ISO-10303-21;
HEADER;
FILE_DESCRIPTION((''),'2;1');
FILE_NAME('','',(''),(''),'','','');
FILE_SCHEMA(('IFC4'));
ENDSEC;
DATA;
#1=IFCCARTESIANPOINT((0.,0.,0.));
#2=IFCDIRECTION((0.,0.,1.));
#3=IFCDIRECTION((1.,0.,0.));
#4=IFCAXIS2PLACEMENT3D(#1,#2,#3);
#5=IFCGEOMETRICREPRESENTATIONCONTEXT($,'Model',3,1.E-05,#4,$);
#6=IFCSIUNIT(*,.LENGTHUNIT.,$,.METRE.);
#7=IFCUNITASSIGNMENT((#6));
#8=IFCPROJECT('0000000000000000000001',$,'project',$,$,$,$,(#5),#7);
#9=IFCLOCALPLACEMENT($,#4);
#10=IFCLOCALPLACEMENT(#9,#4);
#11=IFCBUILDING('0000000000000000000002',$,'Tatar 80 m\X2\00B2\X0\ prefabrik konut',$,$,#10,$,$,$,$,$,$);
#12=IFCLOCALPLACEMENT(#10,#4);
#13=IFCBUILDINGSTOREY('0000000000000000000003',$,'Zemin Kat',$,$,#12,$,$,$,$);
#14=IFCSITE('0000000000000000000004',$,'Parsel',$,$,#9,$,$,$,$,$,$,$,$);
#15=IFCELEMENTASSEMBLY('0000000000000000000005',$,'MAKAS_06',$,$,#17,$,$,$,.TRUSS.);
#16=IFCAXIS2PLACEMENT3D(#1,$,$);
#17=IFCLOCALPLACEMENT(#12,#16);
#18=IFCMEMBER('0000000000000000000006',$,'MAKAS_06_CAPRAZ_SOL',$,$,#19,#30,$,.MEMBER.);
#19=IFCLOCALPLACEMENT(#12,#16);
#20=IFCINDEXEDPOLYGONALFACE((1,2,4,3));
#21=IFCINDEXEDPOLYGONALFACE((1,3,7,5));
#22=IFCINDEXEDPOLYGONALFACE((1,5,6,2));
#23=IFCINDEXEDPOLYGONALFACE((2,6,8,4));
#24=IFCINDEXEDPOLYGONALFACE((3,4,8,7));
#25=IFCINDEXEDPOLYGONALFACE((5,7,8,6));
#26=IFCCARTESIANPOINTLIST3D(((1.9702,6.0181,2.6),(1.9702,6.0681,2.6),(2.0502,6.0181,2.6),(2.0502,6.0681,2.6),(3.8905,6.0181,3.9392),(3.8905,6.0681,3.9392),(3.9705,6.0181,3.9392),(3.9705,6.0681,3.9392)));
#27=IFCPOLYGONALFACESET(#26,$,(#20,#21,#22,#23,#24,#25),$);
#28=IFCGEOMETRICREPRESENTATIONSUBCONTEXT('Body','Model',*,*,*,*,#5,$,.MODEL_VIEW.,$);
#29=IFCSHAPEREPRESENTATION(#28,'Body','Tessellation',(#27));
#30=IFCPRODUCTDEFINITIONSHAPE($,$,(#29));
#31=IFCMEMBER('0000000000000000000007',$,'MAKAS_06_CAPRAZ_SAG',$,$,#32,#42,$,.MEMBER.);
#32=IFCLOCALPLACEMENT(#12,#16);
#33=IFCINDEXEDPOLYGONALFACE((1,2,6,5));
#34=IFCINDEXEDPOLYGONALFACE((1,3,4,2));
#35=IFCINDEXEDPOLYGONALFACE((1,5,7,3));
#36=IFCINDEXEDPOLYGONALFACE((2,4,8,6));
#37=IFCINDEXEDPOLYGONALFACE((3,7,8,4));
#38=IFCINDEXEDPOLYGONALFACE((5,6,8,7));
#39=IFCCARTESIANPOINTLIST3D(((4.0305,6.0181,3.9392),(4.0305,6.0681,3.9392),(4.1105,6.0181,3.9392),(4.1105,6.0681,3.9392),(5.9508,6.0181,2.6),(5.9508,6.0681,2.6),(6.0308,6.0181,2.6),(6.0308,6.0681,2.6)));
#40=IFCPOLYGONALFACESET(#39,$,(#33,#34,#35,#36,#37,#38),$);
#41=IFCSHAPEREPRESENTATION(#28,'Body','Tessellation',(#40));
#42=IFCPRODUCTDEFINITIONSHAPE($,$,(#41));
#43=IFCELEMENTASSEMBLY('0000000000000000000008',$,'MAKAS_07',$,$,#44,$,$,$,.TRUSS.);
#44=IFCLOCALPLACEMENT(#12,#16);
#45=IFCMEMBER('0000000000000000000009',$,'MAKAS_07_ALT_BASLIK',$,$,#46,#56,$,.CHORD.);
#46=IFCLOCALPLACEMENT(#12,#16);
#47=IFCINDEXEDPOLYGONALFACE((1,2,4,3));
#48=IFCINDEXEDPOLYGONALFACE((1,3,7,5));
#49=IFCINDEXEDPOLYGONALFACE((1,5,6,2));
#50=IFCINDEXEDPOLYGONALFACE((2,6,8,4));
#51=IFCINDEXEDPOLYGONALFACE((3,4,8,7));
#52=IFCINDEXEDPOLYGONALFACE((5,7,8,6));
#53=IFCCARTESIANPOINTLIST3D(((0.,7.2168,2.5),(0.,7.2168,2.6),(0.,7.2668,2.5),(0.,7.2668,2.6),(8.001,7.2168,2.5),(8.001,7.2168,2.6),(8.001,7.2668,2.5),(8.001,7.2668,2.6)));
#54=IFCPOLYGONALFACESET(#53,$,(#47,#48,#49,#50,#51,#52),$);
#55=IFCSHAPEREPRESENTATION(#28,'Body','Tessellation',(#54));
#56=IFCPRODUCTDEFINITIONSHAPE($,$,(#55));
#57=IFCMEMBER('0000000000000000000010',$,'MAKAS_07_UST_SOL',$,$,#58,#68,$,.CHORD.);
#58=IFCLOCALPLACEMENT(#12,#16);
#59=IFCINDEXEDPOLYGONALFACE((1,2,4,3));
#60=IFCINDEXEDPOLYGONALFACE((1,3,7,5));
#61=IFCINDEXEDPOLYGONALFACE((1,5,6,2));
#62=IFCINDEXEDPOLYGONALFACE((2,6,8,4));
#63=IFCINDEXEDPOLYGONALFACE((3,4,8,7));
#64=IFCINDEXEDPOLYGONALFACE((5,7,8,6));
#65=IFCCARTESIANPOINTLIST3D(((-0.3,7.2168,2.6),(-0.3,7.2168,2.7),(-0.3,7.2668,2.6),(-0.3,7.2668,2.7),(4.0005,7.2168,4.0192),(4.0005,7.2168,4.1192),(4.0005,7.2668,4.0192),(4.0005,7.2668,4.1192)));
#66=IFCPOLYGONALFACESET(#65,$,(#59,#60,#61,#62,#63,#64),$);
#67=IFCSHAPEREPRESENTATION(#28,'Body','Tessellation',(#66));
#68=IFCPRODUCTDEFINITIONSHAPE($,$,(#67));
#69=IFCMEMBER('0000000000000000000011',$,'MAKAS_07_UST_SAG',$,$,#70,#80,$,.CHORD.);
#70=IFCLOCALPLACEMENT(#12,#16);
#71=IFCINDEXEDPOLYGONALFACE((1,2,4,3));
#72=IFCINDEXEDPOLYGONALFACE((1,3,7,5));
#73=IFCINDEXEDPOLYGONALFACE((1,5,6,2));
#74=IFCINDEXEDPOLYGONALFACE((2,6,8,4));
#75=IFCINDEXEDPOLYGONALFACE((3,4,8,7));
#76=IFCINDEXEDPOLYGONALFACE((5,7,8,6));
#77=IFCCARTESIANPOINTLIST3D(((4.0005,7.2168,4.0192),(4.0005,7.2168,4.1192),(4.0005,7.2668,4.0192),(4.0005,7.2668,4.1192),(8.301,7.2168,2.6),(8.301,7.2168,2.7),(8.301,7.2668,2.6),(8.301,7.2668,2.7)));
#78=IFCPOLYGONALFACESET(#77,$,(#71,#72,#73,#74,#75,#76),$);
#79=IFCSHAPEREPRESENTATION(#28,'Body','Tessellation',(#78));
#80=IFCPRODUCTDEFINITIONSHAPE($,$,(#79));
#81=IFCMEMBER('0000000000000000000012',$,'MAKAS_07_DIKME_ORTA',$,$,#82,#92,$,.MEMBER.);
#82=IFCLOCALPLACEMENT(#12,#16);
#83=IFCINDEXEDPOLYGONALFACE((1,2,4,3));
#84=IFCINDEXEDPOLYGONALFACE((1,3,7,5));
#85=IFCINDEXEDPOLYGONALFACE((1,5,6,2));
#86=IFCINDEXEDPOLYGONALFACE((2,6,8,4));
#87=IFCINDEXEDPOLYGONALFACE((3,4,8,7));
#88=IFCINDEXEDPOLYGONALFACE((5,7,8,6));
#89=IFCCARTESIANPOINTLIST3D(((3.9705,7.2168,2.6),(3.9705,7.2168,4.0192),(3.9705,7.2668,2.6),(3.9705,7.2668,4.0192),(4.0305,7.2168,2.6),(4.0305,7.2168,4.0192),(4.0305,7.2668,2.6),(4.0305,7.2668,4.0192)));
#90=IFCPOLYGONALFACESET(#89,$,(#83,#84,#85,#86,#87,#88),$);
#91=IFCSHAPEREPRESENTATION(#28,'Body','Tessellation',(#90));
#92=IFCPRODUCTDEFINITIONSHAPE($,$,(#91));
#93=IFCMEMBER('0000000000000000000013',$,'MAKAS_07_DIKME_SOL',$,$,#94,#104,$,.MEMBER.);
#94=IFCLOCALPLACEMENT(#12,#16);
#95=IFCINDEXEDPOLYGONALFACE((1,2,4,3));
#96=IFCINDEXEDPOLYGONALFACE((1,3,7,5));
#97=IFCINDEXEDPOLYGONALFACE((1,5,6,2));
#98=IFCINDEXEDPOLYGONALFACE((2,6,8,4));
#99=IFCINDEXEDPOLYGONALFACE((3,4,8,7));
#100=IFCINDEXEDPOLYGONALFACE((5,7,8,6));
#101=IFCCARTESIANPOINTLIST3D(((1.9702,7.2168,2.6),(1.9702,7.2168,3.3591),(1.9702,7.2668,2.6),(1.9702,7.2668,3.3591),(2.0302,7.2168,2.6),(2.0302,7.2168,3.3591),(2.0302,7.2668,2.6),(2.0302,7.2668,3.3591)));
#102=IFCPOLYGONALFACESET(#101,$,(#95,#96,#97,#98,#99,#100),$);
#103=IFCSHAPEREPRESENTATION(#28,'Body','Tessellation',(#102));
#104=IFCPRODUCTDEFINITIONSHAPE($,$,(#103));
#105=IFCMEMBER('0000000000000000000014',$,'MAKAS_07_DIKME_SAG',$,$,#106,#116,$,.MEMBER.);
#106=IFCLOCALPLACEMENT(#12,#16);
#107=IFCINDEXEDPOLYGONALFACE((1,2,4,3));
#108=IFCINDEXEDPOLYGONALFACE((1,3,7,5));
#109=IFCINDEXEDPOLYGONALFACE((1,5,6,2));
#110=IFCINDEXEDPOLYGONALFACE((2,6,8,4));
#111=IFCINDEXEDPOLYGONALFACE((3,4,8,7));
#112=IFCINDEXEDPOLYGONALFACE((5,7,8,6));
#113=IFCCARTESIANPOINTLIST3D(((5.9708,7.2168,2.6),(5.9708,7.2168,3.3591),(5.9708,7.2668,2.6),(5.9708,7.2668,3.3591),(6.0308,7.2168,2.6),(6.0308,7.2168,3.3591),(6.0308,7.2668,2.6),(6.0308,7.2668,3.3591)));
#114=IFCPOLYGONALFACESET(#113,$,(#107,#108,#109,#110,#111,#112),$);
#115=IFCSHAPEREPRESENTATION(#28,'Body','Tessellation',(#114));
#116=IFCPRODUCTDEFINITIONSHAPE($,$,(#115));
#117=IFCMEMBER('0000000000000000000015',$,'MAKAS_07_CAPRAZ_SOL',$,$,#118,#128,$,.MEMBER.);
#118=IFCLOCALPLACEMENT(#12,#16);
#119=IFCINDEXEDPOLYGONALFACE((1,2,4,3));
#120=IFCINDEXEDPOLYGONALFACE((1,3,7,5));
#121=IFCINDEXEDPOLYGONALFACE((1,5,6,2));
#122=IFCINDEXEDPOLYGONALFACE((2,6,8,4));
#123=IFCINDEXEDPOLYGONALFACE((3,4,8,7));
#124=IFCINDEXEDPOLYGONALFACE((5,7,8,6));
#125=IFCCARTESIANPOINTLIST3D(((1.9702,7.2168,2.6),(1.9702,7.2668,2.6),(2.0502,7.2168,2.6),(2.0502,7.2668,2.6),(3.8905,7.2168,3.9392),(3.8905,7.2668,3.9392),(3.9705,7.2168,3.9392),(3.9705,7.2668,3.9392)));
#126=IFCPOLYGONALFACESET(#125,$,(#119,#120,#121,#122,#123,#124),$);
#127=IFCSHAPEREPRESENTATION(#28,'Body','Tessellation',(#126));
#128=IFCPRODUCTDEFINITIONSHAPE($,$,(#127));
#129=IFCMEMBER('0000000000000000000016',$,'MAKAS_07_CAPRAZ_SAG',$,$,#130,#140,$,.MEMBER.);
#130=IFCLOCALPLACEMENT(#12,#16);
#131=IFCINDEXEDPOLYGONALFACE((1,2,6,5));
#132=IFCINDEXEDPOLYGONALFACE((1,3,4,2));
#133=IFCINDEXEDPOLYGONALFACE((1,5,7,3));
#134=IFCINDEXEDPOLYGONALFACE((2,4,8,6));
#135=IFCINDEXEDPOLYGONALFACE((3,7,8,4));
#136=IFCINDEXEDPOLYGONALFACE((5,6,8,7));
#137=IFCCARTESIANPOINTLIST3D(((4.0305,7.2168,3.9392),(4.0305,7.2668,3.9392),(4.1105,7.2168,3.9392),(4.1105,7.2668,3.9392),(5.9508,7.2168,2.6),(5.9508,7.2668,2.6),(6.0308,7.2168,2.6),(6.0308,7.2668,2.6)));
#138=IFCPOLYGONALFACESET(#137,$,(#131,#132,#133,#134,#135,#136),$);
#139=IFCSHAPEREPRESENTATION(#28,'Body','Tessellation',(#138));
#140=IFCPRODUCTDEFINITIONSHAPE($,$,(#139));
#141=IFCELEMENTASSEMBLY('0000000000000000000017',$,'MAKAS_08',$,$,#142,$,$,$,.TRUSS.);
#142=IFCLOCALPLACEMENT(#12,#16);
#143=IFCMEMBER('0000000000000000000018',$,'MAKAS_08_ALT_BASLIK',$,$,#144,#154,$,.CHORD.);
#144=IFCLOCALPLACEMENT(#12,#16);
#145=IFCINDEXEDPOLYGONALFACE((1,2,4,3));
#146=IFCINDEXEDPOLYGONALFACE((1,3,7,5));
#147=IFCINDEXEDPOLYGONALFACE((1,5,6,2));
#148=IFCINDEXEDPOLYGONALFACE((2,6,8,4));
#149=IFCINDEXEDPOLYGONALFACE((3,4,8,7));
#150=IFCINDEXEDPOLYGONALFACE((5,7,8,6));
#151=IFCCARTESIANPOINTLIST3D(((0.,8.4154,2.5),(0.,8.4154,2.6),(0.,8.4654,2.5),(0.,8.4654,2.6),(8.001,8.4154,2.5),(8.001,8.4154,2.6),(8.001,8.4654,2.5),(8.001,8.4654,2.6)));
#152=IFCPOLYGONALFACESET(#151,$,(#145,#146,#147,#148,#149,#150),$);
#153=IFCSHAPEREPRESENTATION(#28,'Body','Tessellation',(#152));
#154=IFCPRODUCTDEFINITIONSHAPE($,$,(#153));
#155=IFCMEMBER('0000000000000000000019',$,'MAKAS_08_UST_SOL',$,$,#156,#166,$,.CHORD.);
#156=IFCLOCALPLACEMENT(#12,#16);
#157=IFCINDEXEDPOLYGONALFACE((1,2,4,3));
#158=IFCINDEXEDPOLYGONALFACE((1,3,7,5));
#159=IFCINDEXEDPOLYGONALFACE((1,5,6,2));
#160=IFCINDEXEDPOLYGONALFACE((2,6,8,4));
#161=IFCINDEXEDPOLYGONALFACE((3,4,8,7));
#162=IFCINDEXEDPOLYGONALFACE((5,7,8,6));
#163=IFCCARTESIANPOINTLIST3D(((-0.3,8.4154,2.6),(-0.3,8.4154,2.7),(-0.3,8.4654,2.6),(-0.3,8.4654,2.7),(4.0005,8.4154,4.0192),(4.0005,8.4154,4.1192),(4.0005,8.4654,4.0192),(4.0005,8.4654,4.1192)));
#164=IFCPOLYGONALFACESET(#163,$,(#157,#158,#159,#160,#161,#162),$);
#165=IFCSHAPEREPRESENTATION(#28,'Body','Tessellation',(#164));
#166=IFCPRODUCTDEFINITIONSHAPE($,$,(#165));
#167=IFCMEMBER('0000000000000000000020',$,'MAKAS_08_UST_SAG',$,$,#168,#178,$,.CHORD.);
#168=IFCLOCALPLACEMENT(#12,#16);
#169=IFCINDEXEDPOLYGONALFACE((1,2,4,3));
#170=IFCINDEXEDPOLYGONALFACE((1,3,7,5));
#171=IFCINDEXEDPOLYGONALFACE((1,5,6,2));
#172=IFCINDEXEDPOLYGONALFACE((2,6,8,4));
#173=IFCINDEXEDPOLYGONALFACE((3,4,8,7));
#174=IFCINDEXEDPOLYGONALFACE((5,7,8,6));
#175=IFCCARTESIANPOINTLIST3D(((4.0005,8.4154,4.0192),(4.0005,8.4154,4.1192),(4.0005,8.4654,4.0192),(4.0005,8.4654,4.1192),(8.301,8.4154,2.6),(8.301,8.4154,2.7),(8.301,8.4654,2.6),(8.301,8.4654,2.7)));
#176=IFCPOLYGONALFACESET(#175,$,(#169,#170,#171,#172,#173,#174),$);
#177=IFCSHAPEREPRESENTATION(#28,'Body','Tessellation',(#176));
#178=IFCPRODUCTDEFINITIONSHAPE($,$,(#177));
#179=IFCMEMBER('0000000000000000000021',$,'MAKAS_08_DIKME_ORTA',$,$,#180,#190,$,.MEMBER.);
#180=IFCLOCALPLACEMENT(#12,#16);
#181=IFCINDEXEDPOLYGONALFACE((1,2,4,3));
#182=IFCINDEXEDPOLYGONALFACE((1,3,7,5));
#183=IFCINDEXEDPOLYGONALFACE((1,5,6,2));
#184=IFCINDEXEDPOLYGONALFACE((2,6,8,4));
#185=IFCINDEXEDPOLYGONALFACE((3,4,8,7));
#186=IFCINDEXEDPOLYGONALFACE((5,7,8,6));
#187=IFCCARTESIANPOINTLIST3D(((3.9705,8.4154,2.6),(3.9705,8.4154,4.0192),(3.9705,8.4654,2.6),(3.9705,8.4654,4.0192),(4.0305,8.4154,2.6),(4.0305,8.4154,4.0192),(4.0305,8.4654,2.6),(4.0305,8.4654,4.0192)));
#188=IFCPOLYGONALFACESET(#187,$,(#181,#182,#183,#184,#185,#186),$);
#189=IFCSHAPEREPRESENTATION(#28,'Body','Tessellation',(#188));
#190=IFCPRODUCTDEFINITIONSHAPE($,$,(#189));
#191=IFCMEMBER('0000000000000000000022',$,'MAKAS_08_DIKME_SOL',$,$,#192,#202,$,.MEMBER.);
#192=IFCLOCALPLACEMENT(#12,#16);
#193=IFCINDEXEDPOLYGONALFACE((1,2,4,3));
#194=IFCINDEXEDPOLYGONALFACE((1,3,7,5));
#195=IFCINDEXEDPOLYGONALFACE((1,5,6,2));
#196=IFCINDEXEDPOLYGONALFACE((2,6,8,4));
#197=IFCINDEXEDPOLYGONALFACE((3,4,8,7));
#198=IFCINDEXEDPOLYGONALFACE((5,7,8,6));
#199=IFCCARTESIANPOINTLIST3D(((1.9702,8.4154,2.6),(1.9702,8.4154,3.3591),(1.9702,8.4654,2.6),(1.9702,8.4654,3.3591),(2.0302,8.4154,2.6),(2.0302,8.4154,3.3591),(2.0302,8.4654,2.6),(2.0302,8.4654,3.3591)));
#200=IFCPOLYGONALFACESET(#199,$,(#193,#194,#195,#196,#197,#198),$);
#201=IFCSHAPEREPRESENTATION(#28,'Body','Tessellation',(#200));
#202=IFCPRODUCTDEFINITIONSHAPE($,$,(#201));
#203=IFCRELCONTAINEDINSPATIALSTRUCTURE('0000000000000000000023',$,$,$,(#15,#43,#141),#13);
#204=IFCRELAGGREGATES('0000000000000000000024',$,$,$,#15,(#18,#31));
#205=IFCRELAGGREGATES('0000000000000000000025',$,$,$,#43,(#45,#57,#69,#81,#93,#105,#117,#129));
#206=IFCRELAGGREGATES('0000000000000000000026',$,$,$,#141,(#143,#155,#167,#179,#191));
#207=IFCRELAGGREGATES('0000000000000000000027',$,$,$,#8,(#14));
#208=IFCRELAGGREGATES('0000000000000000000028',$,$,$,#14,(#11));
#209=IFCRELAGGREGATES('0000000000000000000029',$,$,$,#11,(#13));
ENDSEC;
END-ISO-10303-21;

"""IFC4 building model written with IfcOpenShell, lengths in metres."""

from ifc_helpers import new_model, si_unit, frame, origin_with_axes, place, context, subcontext, project, spatial, line, indexed_curve, outline, extrude, element, aggregate, save


model = new_model("IFC4")

# Units and contexts
model_context = context("Model", 3, precision=1e-05, world=origin_with_axes())
body_context = subcontext(model_context, "Body", "Model", "MODEL_VIEW")
ifc_project = project(units=[si_unit("LENGTHUNIT", "METRE")], contexts=[model_context])

# Site, building, storey
site_placement = place(None, origin_with_axes())
site = spatial("IfcSite", under=ifc_project, at=site_placement, Name="Parsel")
building_placement = place(site_placement, origin_with_axes())
building = spatial("IfcBuilding", under=site, at=building_placement, Name="Tatar 80 m² prefabrik konut")
storey_placement = place(building_placement, origin_with_axes())
storey = spatial("IfcBuildingStorey", under=building, at=storey_placement, Name="Zemin Kat")

# Element assemblies, members
assembly_1_placement = place(storey_placement, origin_with_axes())
assembly_1 = element("IfcElementAssembly", 1, at=assembly_1_placement, inside=storey, Name="MAKAS_06", PredefinedType="TRUSS")
member_1_placement = place(assembly_1_placement, origin_with_axes())
member_1 = element("IfcMember", 2, at=member_1_placement, Name="MAKAS_06_CAPRAZ_SOL", PredefinedType="MEMBER", context=body_context, shape_type="SweptSolid", body=[
    extrude(outline(indexed_curve([(1.9703, 2.6), (2.0503, 2.6), (3.9705, 3.9392), (3.8905, 3.9392)], segments=[line(1, 2, 3, 4, 1)])), frame((0.0, 6.0681, 0.0), z_axis=(0.0, -1.0, 0.0), x_axis=(1.0, 0.0, 0.0)), (0.0, 0.0, 1.0), 0.05),
])
member_2_placement = place(assembly_1_placement, origin_with_axes())
member_2 = element("IfcMember", 3, at=member_2_placement, Name="MAKAS_06_CAPRAZ_SAG", PredefinedType="MEMBER", context=body_context, shape_type="SweptSolid", body=[
    extrude(outline(indexed_curve([(5.9508, 2.6), (6.0308, 2.6), (4.1105, 3.9392), (4.0305, 3.9392)], segments=[line(1, 2, 3, 4, 1)])), frame((0.0, 6.0681, 0.0), z_axis=(0.0, -1.0, 0.0), x_axis=(1.0, 0.0, 0.0)), (0.0, 0.0, 1.0), 0.05),
])
aggregate(assembly_1, [member_1, member_2])
assembly_2_placement = place(storey_placement, origin_with_axes())
assembly_2 = element("IfcElementAssembly", 4, at=assembly_2_placement, inside=storey, Name="MAKAS_07", PredefinedType="TRUSS")
member_3_placement = place(assembly_2_placement, origin_with_axes())
member_3 = element("IfcMember", 5, at=member_3_placement, Name="MAKAS_07_ALT_BASLIK", PredefinedType="CHORD", context=body_context, shape_type="SweptSolid", body=[
    extrude(outline(indexed_curve([(0.0, 2.5), (8.001, 2.5), (8.001, 2.6), (0.0, 2.6)], segments=[line(1, 2, 3, 4, 1)])), frame((0.0, 7.2668, 0.0), z_axis=(0.0, -1.0, 0.0), x_axis=(1.0, 0.0, 0.0)), (0.0, 0.0, 1.0), 0.05),
])
member_4_placement = place(assembly_2_placement, origin_with_axes())
member_4 = element("IfcMember", 6, at=member_4_placement, Name="MAKAS_07_UST_SOL", PredefinedType="CHORD", context=body_context, shape_type="SweptSolid", body=[
    extrude(outline(indexed_curve([(-0.3, 2.6), (4.0005, 4.0192), (4.0005, 4.1192), (-0.3, 2.7)], segments=[line(1, 2, 3, 4, 1)])), frame((0.0, 7.2668, 0.0), z_axis=(0.0, -1.0, 0.0), x_axis=(1.0, 0.0, 0.0)), (0.0, 0.0, 1.0), 0.05),
])
member_5_placement = place(assembly_2_placement, origin_with_axes())
member_5 = element("IfcMember", 7, at=member_5_placement, Name="MAKAS_07_UST_SAG", PredefinedType="CHORD", context=body_context, shape_type="SweptSolid", body=[
    extrude(outline(indexed_curve([(4.0005, 4.0192), (8.301, 2.6), (8.301, 2.7), (4.0005, 4.1192)], segments=[line(1, 2, 3, 4, 1)])), frame((0.0, 7.2668, 0.0), z_axis=(0.0, -1.0, 0.0), x_axis=(1.0, 0.0, 0.0)), (0.0, 0.0, 1.0), 0.05),
])
member_6_placement = place(assembly_2_placement, origin_with_axes())
member_6 = element("IfcMember", 8, at=member_6_placement, Name="MAKAS_07_DIKME_ORTA", PredefinedType="MEMBER", context=body_context, shape_type="SweptSolid", body=[
    extrude(outline(indexed_curve([(3.9705, 2.6), (4.0305, 2.6), (4.0305, 4.0192), (3.9705, 4.0192)], segments=[line(1, 2, 3, 4, 1)])), frame((0.0, 7.2668, 0.0), z_axis=(0.0, -1.0, 0.0), x_axis=(1.0, 0.0, 0.0)), (0.0, 0.0, 1.0), 0.05),
])
member_7_placement = place(assembly_2_placement, origin_with_axes())
member_7 = element("IfcMember", 9, at=member_7_placement, Name="MAKAS_07_DIKME_SOL", PredefinedType="MEMBER", context=body_context, shape_type="SweptSolid", body=[
    extrude(outline(indexed_curve([(1.9703, 2.6), (2.0303, 2.6), (2.0303, 3.3591), (1.9703, 3.3591)], segments=[line(1, 2, 3, 4, 1)])), frame((0.0, 7.2668, 0.0), z_axis=(0.0, -1.0, 0.0), x_axis=(1.0, 0.0, 0.0)), (0.0, 0.0, 1.0), 0.05),
])
member_8_placement = place(assembly_2_placement, origin_with_axes())
member_8 = element("IfcMember", 10, at=member_8_placement, Name="MAKAS_07_DIKME_SAG", PredefinedType="MEMBER", context=body_context, shape_type="SweptSolid", body=[
    extrude(outline(indexed_curve([(5.9708, 2.6), (6.0308, 2.6), (6.0308, 3.3591), (5.9708, 3.3591)], segments=[line(1, 2, 3, 4, 1)])), frame((0.0, 7.2668, 0.0), z_axis=(0.0, -1.0, 0.0), x_axis=(1.0, 0.0, 0.0)), (0.0, 0.0, 1.0), 0.05),
])
member_9_placement = place(assembly_2_placement, origin_with_axes())
member_9 = element("IfcMember", 11, at=member_9_placement, Name="MAKAS_07_CAPRAZ_SOL", PredefinedType="MEMBER", context=body_context, shape_type="SweptSolid", body=[
    extrude(outline(indexed_curve([(1.9703, 2.6), (2.0503, 2.6), (3.9705, 3.9392), (3.8905, 3.9392)], segments=[line(1, 2, 3, 4, 1)])), frame((0.0, 7.2668, 0.0), z_axis=(0.0, -1.0, 0.0), x_axis=(1.0, 0.0, 0.0)), (0.0, 0.0, 1.0), 0.05),
])
member_10_placement = place(assembly_2_placement, origin_with_axes())
member_10 = element("IfcMember", 12, at=member_10_placement, Name="MAKAS_07_CAPRAZ_SAG", PredefinedType="MEMBER", context=body_context, shape_type="SweptSolid", body=[
    extrude(outline(indexed_curve([(5.9508, 2.6), (6.0308, 2.6), (4.1105, 3.9392), (4.0305, 3.9392)], segments=[line(1, 2, 3, 4, 1)])), frame((0.0, 7.2668, 0.0), z_axis=(0.0, -1.0, 0.0), x_axis=(1.0, 0.0, 0.0)), (0.0, 0.0, 1.0), 0.05),
])
aggregate(assembly_2, [member_3, member_4, member_5, member_6, member_7, member_8, member_9, member_10])
assembly_3_placement = place(storey_placement, origin_with_axes())
assembly_3 = element("IfcElementAssembly", 13, at=assembly_3_placement, inside=storey, Name="MAKAS_08", PredefinedType="TRUSS")
member_11_placement = place(assembly_3_placement, origin_with_axes())
member_11 = element("IfcMember", 14, at=member_11_placement, Name="MAKAS_08_ALT_BASLIK", PredefinedType="CHORD", context=body_context, shape_type="SweptSolid", body=[
    extrude(outline(indexed_curve([(0.0, 2.5), (8.001, 2.5), (8.001, 2.6), (0.0, 2.6)], segments=[line(1, 2, 3, 4, 1)])), frame((0.0, 8.4654, 0.0), z_axis=(0.0, -1.0, 0.0), x_axis=(1.0, 0.0, 0.0)), (0.0, 0.0, 1.0), 0.05),
])
member_12_placement = place(assembly_3_placement, origin_with_axes())
member_12 = element("IfcMember", 15, at=member_12_placement, Name="MAKAS_08_UST_SOL", PredefinedType="CHORD", context=body_context, shape_type="SweptSolid", body=[
    extrude(outline(indexed_curve([(-0.3, 2.6), (4.0005, 4.0192), (4.0005, 4.1192), (-0.3, 2.7)], segments=[line(1, 2, 3, 4, 1)])), frame((0.0, 8.4654, 0.0), z_axis=(0.0, -1.0, 0.0), x_axis=(1.0, 0.0, 0.0)), (0.0, 0.0, 1.0), 0.05),
])
member_13_placement = place(assembly_3_placement, origin_with_axes())
member_13 = element("IfcMember", 16, at=member_13_placement, Name="MAKAS_08_UST_SAG", PredefinedType="CHORD", context=body_context, shape_type="SweptSolid", body=[
    extrude(outline(indexed_curve([(4.0005, 4.0192), (8.301, 2.6), (8.301, 2.7), (4.0005, 4.1192)], segments=[line(1, 2, 3, 4, 1)])), frame((0.0, 8.4654, 0.0), z_axis=(0.0, -1.0, 0.0), x_axis=(1.0, 0.0, 0.0)), (0.0, 0.0, 1.0), 0.05),
])
member_14_placement = place(assembly_3_placement, origin_with_axes())
member_14 = element("IfcMember", 17, at=member_14_placement, Name="MAKAS_08_DIKME_ORTA", PredefinedType="MEMBER", context=body_context, shape_type="SweptSolid", body=[
    extrude(outline(indexed_curve([(3.9705, 2.6), (4.0305, 2.6), (4.0305, 4.0192), (3.9705, 4.0192)], segments=[line(1, 2, 3, 4, 1)])), frame((0.0, 8.4654, 0.0), z_axis=(0.0, -1.0, 0.0), x_axis=(1.0, 0.0, 0.0)), (0.0, 0.0, 1.0), 0.05),
])
member_15_placement = place(assembly_3_placement, origin_with_axes())
member_15 = element("IfcMember", 18, at=member_15_placement, Name="MAKAS_08_DIKME_SOL", PredefinedType="MEMBER", context=body_context, shape_type="SweptSolid", body=[
    extrude(outline(indexed_curve([(1.9703, 2.6), (2.0303, 2.6), (2.0303, 3.3591), (1.9703, 3.3591)], segments=[line(1, 2, 3, 4, 1)])), frame((0.0, 8.4654, 0.0), z_axis=(0.0, -1.0, 0.0), x_axis=(1.0, 0.0, 0.0)), (0.0, 0.0, 1.0), 0.05),
])
aggregate(assembly_3, [member_11, member_12, member_13, member_14, member_15])

save(model, "model.ifc")
